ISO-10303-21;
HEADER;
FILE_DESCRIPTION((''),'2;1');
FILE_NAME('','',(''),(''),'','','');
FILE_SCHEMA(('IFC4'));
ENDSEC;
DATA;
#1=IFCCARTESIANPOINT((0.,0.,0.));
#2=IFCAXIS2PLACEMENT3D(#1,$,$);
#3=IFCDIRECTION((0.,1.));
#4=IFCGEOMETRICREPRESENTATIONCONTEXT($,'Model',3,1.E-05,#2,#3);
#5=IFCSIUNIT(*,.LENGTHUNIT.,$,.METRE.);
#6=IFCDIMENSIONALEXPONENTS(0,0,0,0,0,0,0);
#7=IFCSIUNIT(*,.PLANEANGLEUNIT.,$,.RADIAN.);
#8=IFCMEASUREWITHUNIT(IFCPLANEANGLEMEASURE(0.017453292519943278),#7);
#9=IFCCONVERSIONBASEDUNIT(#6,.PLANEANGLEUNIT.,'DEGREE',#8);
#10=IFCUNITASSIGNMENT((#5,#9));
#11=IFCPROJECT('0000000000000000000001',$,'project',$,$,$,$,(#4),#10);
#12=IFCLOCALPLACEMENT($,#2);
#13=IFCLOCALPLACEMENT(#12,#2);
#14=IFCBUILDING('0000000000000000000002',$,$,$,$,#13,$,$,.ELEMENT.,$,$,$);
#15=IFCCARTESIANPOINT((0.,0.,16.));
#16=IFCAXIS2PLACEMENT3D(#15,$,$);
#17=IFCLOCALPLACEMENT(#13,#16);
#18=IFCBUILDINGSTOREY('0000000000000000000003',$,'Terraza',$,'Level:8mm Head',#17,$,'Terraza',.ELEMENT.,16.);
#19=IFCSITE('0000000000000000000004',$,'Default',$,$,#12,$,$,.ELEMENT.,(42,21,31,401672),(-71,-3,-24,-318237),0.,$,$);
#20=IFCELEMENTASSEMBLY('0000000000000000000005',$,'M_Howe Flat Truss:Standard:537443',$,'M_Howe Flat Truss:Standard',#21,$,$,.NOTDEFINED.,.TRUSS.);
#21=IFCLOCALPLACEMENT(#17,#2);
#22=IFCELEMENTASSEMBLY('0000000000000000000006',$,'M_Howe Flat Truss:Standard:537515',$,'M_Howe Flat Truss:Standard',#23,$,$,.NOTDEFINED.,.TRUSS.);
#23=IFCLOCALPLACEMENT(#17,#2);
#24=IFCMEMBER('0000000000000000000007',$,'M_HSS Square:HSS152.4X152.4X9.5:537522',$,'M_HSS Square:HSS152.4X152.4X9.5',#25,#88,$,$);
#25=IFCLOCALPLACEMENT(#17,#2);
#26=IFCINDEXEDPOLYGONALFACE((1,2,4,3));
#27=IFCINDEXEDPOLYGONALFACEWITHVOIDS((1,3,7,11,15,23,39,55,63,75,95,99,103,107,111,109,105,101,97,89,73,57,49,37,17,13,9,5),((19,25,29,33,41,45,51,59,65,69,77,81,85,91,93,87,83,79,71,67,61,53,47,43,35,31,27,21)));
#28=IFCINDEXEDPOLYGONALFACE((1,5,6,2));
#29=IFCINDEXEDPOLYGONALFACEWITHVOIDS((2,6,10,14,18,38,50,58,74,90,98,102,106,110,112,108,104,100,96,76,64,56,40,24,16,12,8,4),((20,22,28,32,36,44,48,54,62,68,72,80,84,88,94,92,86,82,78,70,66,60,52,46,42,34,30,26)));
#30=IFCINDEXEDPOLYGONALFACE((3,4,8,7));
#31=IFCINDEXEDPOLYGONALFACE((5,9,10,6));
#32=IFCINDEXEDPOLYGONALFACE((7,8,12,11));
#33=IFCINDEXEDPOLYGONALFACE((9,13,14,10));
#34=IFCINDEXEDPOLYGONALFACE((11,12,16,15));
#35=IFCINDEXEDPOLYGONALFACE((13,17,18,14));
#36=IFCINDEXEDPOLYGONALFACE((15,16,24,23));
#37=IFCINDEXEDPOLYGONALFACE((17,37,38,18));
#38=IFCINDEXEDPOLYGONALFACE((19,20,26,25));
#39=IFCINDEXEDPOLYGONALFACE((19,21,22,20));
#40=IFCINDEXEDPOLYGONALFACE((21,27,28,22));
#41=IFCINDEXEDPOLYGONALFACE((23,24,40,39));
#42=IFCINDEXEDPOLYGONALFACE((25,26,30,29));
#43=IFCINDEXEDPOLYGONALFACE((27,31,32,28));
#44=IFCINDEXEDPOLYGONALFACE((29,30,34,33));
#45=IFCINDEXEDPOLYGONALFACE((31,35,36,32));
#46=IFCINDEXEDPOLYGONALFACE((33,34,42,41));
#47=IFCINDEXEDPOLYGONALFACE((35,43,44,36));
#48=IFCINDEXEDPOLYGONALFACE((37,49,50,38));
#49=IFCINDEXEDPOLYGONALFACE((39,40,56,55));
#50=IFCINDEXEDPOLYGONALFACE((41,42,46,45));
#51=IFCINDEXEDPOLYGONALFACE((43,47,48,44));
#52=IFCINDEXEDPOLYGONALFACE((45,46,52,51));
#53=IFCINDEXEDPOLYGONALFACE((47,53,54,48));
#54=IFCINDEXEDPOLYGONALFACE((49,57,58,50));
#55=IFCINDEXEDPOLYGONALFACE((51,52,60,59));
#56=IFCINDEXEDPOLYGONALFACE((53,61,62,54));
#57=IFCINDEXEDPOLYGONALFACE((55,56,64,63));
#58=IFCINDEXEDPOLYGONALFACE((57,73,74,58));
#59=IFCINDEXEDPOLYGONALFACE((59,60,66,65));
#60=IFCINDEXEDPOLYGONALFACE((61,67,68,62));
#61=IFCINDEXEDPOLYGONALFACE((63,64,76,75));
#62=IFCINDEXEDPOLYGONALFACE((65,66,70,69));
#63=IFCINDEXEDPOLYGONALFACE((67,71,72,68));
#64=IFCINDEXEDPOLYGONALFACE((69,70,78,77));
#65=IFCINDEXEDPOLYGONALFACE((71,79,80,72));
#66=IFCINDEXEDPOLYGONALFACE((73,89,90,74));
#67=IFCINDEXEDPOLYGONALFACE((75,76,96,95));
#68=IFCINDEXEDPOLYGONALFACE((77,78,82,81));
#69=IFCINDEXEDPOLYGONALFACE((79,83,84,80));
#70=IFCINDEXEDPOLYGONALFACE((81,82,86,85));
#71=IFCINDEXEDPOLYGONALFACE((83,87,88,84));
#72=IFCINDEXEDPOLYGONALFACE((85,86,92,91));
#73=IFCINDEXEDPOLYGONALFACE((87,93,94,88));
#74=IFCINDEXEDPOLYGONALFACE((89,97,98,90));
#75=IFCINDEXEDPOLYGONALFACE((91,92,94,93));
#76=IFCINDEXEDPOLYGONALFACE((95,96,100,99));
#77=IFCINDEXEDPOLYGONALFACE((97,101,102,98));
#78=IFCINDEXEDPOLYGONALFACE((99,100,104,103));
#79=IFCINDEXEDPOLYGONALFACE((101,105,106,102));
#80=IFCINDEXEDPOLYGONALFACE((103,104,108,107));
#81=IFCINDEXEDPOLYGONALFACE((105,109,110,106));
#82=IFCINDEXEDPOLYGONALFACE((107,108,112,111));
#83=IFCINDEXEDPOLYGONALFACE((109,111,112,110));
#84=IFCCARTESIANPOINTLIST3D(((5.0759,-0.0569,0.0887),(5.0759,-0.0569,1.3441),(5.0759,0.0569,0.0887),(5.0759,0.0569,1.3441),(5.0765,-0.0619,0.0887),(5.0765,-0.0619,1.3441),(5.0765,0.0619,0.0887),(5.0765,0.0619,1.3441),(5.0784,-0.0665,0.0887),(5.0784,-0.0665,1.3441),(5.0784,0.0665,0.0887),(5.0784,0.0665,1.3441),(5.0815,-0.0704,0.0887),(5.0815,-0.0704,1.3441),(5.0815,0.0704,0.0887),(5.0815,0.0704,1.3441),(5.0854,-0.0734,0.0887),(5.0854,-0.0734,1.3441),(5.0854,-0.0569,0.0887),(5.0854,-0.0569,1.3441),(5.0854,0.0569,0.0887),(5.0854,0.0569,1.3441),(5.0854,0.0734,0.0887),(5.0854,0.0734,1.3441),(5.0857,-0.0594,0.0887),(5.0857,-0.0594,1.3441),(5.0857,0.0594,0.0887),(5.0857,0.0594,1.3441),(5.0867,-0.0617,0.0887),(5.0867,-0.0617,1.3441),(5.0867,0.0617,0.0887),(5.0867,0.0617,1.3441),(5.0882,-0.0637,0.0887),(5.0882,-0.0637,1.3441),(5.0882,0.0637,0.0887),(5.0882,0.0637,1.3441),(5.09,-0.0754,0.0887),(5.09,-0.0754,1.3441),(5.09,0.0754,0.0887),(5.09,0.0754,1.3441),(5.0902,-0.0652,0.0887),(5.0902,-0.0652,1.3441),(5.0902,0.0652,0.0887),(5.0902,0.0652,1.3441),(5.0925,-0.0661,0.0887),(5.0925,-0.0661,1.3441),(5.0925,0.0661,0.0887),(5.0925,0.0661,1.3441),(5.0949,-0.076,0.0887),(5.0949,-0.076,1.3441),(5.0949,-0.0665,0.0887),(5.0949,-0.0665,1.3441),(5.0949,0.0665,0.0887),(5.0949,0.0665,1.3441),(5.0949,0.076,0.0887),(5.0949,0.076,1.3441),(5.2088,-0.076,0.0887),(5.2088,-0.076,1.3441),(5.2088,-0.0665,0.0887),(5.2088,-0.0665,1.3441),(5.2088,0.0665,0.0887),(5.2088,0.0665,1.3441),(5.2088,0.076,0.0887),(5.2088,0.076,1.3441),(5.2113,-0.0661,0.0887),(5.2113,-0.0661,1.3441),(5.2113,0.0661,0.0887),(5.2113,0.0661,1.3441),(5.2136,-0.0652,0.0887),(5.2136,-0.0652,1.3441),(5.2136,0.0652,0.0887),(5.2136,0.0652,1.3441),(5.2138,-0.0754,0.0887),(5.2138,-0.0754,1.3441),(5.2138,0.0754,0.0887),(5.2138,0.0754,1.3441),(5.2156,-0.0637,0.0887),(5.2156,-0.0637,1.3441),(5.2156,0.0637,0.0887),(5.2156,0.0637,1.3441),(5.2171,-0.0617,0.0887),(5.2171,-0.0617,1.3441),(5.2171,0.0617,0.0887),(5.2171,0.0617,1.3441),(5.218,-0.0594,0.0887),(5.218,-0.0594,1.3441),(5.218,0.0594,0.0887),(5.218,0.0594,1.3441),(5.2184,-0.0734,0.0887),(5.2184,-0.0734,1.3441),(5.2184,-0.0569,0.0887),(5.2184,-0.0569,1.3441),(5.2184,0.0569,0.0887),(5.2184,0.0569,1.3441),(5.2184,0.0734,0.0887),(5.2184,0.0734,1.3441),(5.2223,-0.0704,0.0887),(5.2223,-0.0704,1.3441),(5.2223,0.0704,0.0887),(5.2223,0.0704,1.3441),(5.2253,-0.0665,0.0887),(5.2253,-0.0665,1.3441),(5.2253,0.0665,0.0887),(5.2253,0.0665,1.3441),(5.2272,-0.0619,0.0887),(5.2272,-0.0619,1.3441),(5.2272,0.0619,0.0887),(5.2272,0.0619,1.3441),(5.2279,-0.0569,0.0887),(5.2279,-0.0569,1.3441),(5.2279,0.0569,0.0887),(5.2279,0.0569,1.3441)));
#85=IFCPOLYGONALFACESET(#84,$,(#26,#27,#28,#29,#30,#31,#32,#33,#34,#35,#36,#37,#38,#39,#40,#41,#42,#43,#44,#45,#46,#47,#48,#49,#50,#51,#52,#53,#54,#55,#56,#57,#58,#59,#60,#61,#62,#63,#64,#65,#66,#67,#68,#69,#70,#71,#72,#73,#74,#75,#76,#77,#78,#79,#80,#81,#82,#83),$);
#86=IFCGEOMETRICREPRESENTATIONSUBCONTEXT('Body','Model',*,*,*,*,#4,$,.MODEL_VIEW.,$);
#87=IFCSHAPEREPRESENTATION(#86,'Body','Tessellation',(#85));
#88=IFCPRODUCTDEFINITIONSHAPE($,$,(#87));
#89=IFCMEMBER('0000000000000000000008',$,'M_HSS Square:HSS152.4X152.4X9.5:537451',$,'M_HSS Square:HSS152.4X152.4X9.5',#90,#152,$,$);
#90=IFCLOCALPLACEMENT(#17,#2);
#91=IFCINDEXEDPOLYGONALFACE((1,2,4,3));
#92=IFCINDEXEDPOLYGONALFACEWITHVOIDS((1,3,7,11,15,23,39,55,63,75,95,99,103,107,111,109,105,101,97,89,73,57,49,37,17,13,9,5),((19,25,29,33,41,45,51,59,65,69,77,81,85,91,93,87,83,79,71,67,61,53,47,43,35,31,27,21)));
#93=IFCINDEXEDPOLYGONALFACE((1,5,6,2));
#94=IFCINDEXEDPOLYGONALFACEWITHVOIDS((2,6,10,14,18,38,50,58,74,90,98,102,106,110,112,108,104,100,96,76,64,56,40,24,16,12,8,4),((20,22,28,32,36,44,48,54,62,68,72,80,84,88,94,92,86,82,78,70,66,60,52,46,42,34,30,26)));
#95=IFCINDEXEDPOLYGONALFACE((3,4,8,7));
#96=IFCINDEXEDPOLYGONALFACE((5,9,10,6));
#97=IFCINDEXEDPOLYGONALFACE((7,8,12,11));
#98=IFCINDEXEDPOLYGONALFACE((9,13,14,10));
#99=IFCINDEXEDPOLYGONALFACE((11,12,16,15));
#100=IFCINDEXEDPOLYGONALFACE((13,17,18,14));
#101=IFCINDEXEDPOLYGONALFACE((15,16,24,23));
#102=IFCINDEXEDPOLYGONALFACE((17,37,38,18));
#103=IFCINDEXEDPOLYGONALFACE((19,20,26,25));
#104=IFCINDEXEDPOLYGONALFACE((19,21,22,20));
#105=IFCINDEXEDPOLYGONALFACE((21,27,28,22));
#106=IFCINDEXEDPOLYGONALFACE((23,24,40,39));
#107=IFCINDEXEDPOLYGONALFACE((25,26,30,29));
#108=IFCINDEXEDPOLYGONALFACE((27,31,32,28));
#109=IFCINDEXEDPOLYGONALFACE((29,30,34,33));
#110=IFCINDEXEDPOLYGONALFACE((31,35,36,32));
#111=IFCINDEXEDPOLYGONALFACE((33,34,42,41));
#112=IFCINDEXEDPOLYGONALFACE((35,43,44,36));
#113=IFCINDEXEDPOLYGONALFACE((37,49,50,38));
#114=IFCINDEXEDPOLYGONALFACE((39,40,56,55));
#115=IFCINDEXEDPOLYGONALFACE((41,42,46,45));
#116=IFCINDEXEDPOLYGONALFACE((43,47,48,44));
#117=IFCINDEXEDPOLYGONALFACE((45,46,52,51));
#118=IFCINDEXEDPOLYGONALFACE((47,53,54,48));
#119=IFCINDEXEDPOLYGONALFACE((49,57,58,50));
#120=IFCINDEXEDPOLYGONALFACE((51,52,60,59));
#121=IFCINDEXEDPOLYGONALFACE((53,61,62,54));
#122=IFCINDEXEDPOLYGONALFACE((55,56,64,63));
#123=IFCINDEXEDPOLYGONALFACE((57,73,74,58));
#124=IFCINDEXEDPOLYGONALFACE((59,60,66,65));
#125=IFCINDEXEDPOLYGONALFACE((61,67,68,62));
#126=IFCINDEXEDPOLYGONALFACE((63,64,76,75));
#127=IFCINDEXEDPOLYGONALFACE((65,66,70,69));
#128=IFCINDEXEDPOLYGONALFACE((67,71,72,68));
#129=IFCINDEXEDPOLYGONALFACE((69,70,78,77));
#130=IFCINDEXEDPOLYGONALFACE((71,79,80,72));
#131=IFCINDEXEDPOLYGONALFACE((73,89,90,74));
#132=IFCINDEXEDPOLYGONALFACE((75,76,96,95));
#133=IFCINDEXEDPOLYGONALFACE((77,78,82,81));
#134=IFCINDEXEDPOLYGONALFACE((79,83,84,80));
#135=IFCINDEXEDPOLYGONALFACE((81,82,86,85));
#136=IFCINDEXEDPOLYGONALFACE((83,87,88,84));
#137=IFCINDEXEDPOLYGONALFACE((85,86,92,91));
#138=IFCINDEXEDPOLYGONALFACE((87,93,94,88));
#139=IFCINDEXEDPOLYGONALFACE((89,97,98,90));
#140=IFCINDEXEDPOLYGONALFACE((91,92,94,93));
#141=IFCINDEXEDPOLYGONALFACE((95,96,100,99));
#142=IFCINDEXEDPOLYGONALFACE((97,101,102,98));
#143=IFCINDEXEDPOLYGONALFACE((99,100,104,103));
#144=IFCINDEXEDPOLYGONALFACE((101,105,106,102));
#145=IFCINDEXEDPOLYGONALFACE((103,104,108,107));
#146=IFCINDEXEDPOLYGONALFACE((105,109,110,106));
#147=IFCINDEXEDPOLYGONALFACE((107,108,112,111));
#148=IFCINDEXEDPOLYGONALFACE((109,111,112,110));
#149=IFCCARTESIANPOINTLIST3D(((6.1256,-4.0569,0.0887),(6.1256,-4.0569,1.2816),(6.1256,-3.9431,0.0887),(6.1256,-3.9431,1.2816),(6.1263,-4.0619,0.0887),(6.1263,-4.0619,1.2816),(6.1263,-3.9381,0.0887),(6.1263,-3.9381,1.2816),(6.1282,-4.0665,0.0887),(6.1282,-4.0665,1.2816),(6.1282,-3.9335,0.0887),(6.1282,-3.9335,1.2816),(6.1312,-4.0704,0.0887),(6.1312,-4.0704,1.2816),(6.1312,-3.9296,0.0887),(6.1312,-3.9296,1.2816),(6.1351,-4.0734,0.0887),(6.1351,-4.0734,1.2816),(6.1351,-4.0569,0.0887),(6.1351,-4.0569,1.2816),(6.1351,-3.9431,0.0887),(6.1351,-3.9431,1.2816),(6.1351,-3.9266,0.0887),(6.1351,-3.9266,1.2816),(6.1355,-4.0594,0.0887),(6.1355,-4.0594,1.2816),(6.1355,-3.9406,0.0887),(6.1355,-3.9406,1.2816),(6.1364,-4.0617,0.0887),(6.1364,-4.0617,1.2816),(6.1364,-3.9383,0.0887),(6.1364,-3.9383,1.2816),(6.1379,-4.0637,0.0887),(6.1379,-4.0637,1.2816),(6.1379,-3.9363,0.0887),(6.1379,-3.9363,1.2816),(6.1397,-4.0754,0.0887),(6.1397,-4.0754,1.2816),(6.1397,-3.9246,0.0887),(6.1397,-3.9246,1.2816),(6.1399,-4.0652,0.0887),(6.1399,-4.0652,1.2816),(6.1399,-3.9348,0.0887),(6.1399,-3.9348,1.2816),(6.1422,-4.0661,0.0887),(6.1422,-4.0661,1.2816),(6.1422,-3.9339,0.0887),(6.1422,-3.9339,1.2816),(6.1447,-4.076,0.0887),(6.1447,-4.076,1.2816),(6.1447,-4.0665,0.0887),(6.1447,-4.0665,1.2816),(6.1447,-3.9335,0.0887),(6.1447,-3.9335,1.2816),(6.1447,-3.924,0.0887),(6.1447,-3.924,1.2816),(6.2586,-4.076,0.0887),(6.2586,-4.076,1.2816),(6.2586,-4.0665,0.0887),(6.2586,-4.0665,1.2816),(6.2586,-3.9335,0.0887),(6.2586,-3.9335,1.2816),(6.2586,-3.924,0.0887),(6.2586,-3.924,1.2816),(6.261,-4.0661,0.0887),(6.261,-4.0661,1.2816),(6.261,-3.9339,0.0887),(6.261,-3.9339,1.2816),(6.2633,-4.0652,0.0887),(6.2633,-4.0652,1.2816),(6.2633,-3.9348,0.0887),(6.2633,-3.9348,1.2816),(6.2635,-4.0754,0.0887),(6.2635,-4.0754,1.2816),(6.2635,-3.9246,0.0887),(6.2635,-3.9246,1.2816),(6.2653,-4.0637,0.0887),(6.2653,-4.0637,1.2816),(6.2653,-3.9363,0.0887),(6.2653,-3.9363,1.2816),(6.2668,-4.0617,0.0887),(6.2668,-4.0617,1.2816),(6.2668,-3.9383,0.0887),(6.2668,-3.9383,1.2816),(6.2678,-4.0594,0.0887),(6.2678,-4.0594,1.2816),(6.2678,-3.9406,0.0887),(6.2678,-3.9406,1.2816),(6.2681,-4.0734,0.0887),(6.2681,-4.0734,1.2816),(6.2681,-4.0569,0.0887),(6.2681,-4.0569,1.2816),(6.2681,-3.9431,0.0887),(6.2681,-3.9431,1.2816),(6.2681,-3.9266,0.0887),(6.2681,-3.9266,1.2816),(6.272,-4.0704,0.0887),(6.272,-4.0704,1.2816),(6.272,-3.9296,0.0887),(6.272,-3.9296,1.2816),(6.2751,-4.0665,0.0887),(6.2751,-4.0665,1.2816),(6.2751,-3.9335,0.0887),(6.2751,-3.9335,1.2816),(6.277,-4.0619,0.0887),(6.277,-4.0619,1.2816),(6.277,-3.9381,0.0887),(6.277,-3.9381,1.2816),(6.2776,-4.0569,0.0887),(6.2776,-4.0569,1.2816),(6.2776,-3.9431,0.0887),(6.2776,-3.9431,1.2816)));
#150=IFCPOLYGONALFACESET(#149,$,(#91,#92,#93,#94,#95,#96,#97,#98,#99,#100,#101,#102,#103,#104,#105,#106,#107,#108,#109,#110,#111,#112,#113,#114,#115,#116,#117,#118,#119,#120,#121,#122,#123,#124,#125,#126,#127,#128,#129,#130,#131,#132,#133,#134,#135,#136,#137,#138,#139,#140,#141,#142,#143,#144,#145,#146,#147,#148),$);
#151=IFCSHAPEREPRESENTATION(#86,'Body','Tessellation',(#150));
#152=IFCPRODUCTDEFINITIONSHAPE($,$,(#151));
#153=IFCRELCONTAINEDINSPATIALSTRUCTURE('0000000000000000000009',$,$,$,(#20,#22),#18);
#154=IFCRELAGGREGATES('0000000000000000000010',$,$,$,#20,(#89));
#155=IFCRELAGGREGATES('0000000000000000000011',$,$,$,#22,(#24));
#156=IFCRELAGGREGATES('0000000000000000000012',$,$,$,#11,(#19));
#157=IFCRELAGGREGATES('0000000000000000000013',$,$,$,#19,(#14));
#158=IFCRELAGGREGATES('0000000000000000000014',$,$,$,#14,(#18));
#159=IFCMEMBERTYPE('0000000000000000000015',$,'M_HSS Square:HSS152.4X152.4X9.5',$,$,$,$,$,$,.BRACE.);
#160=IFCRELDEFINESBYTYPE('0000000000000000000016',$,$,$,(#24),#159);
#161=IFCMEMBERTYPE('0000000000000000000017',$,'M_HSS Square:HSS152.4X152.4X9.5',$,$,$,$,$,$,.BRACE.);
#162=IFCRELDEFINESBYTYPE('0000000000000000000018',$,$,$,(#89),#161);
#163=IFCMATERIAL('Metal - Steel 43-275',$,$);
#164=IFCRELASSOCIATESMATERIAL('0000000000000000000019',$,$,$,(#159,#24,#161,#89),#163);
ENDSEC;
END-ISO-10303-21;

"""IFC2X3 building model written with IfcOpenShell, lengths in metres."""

from ifc_helpers import new_model, entity, si_unit, converted_unit, direction, frame, frame_2d, origin, place, context, subcontext, project, spatial, polyline, circle_curve, parameter, trimmed, segment, composite_curve, outline, extrude, source, transform, mapped, material, type_object, type_shapes, element, aggregate, save


model = new_model("IFC2X3")

# Units and contexts
model_context = context("Model", 3, precision=1e-05, world=origin(), true_north=direction((0.0, 1.0)))
body_context = subcontext(model_context, "Body", "Model", "MODEL_VIEW")
ifc_project = project(units=[si_unit("LENGTHUNIT", "METRE"), converted_unit("PLANEANGLEUNIT", "DEGREE", entity("IfcPlaneAngleMeasure", 0.017453292519943278), si_unit("PLANEANGLEUNIT", "RADIAN"), dimensions=[0, 0, 0, 0, 0, 0, 0])], contexts=[model_context])

# Site, building, storey
site_placement = place(None, origin())
site = spatial("IfcSite", under=ifc_project, at=site_placement, Name="Default", CompositionType="ELEMENT", RefLatitude=(42, 21, 31, 401672), RefLongitude=(-71, -3, -24, -318237), RefElevation=0.0)
building_placement = place(site_placement, origin())
building = spatial("IfcBuilding", under=site, at=building_placement, CompositionType="ELEMENT")
storey_placement = place(building_placement, frame((0.0, 0.0, 16.0)))
storey = spatial("IfcBuildingStorey", under=building, at=storey_placement, Name="Terraza", ObjectType="Level:8mm Head", LongName="Terraza", CompositionType="ELEMENT", Elevation=16.0)

# Element assemblies
ifc_material_1 = material(Name="Metal - Steel 43-275")
assembly_1_placement = place(storey_placement, origin())
assembly_1 = element("IfcElementAssembly", 1, at=assembly_1_placement, inside=storey, Name="M_Howe Flat Truss:Standard:537443", ObjectType="M_Howe Flat Truss:Standard", AssemblyPlace="NOTDEFINED", PredefinedType="TRUSS")
assembly_2_placement = place(storey_placement, origin())
assembly_2 = element("IfcElementAssembly", 2, at=assembly_2_placement, inside=storey, Name="M_Howe Flat Truss:Standard:537515", ObjectType="M_Howe Flat Truss:Standard", AssemblyPlace="NOTDEFINED", PredefinedType="TRUSS")

# Members
member_type_1 = type_object("IfcMemberType", Name="M_HSS Square:HSS152.4X152.4X9.5", PredefinedType="BRACE", material=ifc_material_1)
shared_shape_1 = source(origin(), body_context, "Body", "SweptSolid", [
    extrude(outline(composite_curve([segment(polyline([(-0.0569, -0.076), (0.0569, -0.076)]), True, "CONTINUOUS"), segment(trimmed(circle_curve(frame_2d((0.0569, -0.0569), x_axis=(0.0, 1.0)), 0.0191), [parameter(180.0)], [parameter(270.0)], True, "PARAMETER"), True, "CONTINUOUS"), segment(polyline([(0.076, -0.0569), (0.076, 0.0569)]), True, "CONTINUOUS"), segment(trimmed(circle_curve(frame_2d((0.0569, 0.0569), x_axis=(0.0, 1.0)), 0.0191), [parameter(270.0)], [parameter(0.0)], True, "PARAMETER"), True, "CONTINUOUS"), segment(polyline([(0.0569, 0.076), (-0.0569, 0.076)]), True, "CONTINUOUS"), segment(trimmed(circle_curve(frame_2d((-0.0569, 0.0569), x_axis=(0.0, 1.0)), 0.0191), [parameter(0.0)], [parameter(90.0)], True, "PARAMETER"), True, "CONTINUOUS"), segment(polyline([(-0.076, 0.0569), (-0.076, -0.0569)]), True, "CONTINUOUS"), segment(trimmed(circle_curve(frame_2d((-0.0569, -0.0569), x_axis=(0.0, 1.0)), 0.0191), [parameter(90.0)], [parameter(180.0)], True, "PARAMETER"), True, "CONTINUOUS")], self_intersect=False), holes=[composite_curve([segment(trimmed(circle_curve(frame_2d((-0.0569, 0.0569), x_axis=(0.0, 1.0)), 0.0095), [parameter(360.0)], [parameter(90.0)], True, "PARAMETER"), False, "CONTINUOUS"), segment(polyline([(-0.0569, 0.0665), (0.0569, 0.0665)]), True, "CONTINUOUS"), segment(trimmed(circle_curve(frame_2d((0.0569, 0.0569), x_axis=(0.0, 1.0)), 0.0095), [parameter(270.0)], [parameter(360.0)], True, "PARAMETER"), False, "CONTINUOUS"), segment(polyline([(0.0665, 0.0569), (0.0665, -0.0569)]), True, "CONTINUOUS"), segment(trimmed(circle_curve(frame_2d((0.0569, -0.0569), x_axis=(0.0, 1.0)), 0.0095), [parameter(180.0)], [parameter(270.0)], True, "PARAMETER"), False, "CONTINUOUS"), segment(polyline([(0.0569, -0.0665), (-0.0569, -0.0665)]), True, "CONTINUOUS"), segment(trimmed(circle_curve(frame_2d((-0.0569, -0.0569), x_axis=(0.0, 1.0)), 0.0095), [parameter(90.0)], [parameter(180.0)], True, "PARAMETER"), False, "CONTINUOUS"), segment(polyline([(-0.0665, -0.0569), (-0.0665, 0.0569)]), True, "CONTINUOUS")], self_intersect=False)]), frame((-0.63, 0.0, 0.0), z_axis=(1.0, 0.0, 0.0), x_axis=(0.0, 0.0, -1.0)), (0.0, 0.0, 1.0), 1.2554),
])
type_shapes(member_type_1, [shared_shape_1])
member_1_placement = place(assembly_2_placement, frame((5.1519, 0.0, 0.7187), z_axis=(1.0, 0.0, 0.0), x_axis=(0.0, 0.0, 1.0)))
member_1 = element("IfcMember", 3, at=member_1_placement, type_object=member_type_1, material=ifc_material_1, Name="M_HSS Square:HSS152.4X152.4X9.5:537522", ObjectType="M_HSS Square:HSS152.4X152.4X9.5", context=body_context, shape_type="MappedRepresentation", body=[
    mapped(shared_shape_1, transform((0.0, 0.0, 0.0), scale=1.0)),
])
member_type_2 = type_object("IfcMemberType", Name="M_HSS Square:HSS152.4X152.4X9.5", PredefinedType="BRACE", material=ifc_material_1)
shared_shape_2 = source(origin(), body_context, "Body", "SweptSolid", [
    extrude(outline(composite_curve([segment(polyline([(-0.0569, -0.076), (0.0569, -0.076)]), True, "CONTINUOUS"), segment(trimmed(circle_curve(frame_2d((0.0569, -0.0569), x_axis=(0.0, 1.0)), 0.0191), [parameter(180.0)], [parameter(270.0)], True, "PARAMETER"), True, "CONTINUOUS"), segment(polyline([(0.076, -0.0569), (0.076, 0.0569)]), True, "CONTINUOUS"), segment(trimmed(circle_curve(frame_2d((0.0569, 0.0569), x_axis=(0.0, 1.0)), 0.0191), [parameter(270.0)], [parameter(0.0)], True, "PARAMETER"), True, "CONTINUOUS"), segment(polyline([(0.0569, 0.076), (-0.0569, 0.076)]), True, "CONTINUOUS"), segment(trimmed(circle_curve(frame_2d((-0.0569, 0.0569), x_axis=(0.0, 1.0)), 0.0191), [parameter(0.0)], [parameter(90.0)], True, "PARAMETER"), True, "CONTINUOUS"), segment(polyline([(-0.076, 0.0569), (-0.076, -0.0569)]), True, "CONTINUOUS"), segment(trimmed(circle_curve(frame_2d((-0.0569, -0.0569), x_axis=(0.0, 1.0)), 0.0191), [parameter(90.0)], [parameter(180.0)], True, "PARAMETER"), True, "CONTINUOUS")], self_intersect=False), holes=[composite_curve([segment(trimmed(circle_curve(frame_2d((-0.0569, 0.0569), x_axis=(0.0, 1.0)), 0.0095), [parameter(360.0)], [parameter(90.0)], True, "PARAMETER"), False, "CONTINUOUS"), segment(polyline([(-0.0569, 0.0665), (0.0569, 0.0665)]), True, "CONTINUOUS"), segment(trimmed(circle_curve(frame_2d((0.0569, 0.0569), x_axis=(0.0, 1.0)), 0.0095), [parameter(270.0)], [parameter(360.0)], True, "PARAMETER"), False, "CONTINUOUS"), segment(polyline([(0.0665, 0.0569), (0.0665, -0.0569)]), True, "CONTINUOUS"), segment(trimmed(circle_curve(frame_2d((0.0569, -0.0569), x_axis=(0.0, 1.0)), 0.0095), [parameter(180.0)], [parameter(270.0)], True, "PARAMETER"), False, "CONTINUOUS"), segment(polyline([(0.0569, -0.0665), (-0.0569, -0.0665)]), True, "CONTINUOUS"), segment(trimmed(circle_curve(frame_2d((-0.0569, -0.0569), x_axis=(0.0, 1.0)), 0.0095), [parameter(90.0)], [parameter(180.0)], True, "PARAMETER"), False, "CONTINUOUS"), segment(polyline([(-0.0665, -0.0569), (-0.0665, 0.0569)]), True, "CONTINUOUS")], self_intersect=False)]), frame((-0.5988, 0.0, 0.0), z_axis=(1.0, 0.0, 0.0), x_axis=(0.0, 0.0, -1.0)), (0.0, 0.0, 1.0), 1.1929),
])
type_shapes(member_type_2, [shared_shape_2])
member_2_placement = place(assembly_1_placement, frame((6.2016, -4.0, 0.6875), z_axis=(1.0, 0.0, 0.0), x_axis=(0.0, 0.0, 1.0)))
member_2 = element("IfcMember", 4, at=member_2_placement, type_object=member_type_2, material=ifc_material_1, Name="M_HSS Square:HSS152.4X152.4X9.5:537451", ObjectType="M_HSS Square:HSS152.4X152.4X9.5", context=body_context, shape_type="MappedRepresentation", body=[
    mapped(shared_shape_2, transform((0.0, 0.0, 0.0), scale=1.0)),
])
aggregate(assembly_1, [member_2])
aggregate(assembly_2, [member_1])

save(model, "model.ifc")
